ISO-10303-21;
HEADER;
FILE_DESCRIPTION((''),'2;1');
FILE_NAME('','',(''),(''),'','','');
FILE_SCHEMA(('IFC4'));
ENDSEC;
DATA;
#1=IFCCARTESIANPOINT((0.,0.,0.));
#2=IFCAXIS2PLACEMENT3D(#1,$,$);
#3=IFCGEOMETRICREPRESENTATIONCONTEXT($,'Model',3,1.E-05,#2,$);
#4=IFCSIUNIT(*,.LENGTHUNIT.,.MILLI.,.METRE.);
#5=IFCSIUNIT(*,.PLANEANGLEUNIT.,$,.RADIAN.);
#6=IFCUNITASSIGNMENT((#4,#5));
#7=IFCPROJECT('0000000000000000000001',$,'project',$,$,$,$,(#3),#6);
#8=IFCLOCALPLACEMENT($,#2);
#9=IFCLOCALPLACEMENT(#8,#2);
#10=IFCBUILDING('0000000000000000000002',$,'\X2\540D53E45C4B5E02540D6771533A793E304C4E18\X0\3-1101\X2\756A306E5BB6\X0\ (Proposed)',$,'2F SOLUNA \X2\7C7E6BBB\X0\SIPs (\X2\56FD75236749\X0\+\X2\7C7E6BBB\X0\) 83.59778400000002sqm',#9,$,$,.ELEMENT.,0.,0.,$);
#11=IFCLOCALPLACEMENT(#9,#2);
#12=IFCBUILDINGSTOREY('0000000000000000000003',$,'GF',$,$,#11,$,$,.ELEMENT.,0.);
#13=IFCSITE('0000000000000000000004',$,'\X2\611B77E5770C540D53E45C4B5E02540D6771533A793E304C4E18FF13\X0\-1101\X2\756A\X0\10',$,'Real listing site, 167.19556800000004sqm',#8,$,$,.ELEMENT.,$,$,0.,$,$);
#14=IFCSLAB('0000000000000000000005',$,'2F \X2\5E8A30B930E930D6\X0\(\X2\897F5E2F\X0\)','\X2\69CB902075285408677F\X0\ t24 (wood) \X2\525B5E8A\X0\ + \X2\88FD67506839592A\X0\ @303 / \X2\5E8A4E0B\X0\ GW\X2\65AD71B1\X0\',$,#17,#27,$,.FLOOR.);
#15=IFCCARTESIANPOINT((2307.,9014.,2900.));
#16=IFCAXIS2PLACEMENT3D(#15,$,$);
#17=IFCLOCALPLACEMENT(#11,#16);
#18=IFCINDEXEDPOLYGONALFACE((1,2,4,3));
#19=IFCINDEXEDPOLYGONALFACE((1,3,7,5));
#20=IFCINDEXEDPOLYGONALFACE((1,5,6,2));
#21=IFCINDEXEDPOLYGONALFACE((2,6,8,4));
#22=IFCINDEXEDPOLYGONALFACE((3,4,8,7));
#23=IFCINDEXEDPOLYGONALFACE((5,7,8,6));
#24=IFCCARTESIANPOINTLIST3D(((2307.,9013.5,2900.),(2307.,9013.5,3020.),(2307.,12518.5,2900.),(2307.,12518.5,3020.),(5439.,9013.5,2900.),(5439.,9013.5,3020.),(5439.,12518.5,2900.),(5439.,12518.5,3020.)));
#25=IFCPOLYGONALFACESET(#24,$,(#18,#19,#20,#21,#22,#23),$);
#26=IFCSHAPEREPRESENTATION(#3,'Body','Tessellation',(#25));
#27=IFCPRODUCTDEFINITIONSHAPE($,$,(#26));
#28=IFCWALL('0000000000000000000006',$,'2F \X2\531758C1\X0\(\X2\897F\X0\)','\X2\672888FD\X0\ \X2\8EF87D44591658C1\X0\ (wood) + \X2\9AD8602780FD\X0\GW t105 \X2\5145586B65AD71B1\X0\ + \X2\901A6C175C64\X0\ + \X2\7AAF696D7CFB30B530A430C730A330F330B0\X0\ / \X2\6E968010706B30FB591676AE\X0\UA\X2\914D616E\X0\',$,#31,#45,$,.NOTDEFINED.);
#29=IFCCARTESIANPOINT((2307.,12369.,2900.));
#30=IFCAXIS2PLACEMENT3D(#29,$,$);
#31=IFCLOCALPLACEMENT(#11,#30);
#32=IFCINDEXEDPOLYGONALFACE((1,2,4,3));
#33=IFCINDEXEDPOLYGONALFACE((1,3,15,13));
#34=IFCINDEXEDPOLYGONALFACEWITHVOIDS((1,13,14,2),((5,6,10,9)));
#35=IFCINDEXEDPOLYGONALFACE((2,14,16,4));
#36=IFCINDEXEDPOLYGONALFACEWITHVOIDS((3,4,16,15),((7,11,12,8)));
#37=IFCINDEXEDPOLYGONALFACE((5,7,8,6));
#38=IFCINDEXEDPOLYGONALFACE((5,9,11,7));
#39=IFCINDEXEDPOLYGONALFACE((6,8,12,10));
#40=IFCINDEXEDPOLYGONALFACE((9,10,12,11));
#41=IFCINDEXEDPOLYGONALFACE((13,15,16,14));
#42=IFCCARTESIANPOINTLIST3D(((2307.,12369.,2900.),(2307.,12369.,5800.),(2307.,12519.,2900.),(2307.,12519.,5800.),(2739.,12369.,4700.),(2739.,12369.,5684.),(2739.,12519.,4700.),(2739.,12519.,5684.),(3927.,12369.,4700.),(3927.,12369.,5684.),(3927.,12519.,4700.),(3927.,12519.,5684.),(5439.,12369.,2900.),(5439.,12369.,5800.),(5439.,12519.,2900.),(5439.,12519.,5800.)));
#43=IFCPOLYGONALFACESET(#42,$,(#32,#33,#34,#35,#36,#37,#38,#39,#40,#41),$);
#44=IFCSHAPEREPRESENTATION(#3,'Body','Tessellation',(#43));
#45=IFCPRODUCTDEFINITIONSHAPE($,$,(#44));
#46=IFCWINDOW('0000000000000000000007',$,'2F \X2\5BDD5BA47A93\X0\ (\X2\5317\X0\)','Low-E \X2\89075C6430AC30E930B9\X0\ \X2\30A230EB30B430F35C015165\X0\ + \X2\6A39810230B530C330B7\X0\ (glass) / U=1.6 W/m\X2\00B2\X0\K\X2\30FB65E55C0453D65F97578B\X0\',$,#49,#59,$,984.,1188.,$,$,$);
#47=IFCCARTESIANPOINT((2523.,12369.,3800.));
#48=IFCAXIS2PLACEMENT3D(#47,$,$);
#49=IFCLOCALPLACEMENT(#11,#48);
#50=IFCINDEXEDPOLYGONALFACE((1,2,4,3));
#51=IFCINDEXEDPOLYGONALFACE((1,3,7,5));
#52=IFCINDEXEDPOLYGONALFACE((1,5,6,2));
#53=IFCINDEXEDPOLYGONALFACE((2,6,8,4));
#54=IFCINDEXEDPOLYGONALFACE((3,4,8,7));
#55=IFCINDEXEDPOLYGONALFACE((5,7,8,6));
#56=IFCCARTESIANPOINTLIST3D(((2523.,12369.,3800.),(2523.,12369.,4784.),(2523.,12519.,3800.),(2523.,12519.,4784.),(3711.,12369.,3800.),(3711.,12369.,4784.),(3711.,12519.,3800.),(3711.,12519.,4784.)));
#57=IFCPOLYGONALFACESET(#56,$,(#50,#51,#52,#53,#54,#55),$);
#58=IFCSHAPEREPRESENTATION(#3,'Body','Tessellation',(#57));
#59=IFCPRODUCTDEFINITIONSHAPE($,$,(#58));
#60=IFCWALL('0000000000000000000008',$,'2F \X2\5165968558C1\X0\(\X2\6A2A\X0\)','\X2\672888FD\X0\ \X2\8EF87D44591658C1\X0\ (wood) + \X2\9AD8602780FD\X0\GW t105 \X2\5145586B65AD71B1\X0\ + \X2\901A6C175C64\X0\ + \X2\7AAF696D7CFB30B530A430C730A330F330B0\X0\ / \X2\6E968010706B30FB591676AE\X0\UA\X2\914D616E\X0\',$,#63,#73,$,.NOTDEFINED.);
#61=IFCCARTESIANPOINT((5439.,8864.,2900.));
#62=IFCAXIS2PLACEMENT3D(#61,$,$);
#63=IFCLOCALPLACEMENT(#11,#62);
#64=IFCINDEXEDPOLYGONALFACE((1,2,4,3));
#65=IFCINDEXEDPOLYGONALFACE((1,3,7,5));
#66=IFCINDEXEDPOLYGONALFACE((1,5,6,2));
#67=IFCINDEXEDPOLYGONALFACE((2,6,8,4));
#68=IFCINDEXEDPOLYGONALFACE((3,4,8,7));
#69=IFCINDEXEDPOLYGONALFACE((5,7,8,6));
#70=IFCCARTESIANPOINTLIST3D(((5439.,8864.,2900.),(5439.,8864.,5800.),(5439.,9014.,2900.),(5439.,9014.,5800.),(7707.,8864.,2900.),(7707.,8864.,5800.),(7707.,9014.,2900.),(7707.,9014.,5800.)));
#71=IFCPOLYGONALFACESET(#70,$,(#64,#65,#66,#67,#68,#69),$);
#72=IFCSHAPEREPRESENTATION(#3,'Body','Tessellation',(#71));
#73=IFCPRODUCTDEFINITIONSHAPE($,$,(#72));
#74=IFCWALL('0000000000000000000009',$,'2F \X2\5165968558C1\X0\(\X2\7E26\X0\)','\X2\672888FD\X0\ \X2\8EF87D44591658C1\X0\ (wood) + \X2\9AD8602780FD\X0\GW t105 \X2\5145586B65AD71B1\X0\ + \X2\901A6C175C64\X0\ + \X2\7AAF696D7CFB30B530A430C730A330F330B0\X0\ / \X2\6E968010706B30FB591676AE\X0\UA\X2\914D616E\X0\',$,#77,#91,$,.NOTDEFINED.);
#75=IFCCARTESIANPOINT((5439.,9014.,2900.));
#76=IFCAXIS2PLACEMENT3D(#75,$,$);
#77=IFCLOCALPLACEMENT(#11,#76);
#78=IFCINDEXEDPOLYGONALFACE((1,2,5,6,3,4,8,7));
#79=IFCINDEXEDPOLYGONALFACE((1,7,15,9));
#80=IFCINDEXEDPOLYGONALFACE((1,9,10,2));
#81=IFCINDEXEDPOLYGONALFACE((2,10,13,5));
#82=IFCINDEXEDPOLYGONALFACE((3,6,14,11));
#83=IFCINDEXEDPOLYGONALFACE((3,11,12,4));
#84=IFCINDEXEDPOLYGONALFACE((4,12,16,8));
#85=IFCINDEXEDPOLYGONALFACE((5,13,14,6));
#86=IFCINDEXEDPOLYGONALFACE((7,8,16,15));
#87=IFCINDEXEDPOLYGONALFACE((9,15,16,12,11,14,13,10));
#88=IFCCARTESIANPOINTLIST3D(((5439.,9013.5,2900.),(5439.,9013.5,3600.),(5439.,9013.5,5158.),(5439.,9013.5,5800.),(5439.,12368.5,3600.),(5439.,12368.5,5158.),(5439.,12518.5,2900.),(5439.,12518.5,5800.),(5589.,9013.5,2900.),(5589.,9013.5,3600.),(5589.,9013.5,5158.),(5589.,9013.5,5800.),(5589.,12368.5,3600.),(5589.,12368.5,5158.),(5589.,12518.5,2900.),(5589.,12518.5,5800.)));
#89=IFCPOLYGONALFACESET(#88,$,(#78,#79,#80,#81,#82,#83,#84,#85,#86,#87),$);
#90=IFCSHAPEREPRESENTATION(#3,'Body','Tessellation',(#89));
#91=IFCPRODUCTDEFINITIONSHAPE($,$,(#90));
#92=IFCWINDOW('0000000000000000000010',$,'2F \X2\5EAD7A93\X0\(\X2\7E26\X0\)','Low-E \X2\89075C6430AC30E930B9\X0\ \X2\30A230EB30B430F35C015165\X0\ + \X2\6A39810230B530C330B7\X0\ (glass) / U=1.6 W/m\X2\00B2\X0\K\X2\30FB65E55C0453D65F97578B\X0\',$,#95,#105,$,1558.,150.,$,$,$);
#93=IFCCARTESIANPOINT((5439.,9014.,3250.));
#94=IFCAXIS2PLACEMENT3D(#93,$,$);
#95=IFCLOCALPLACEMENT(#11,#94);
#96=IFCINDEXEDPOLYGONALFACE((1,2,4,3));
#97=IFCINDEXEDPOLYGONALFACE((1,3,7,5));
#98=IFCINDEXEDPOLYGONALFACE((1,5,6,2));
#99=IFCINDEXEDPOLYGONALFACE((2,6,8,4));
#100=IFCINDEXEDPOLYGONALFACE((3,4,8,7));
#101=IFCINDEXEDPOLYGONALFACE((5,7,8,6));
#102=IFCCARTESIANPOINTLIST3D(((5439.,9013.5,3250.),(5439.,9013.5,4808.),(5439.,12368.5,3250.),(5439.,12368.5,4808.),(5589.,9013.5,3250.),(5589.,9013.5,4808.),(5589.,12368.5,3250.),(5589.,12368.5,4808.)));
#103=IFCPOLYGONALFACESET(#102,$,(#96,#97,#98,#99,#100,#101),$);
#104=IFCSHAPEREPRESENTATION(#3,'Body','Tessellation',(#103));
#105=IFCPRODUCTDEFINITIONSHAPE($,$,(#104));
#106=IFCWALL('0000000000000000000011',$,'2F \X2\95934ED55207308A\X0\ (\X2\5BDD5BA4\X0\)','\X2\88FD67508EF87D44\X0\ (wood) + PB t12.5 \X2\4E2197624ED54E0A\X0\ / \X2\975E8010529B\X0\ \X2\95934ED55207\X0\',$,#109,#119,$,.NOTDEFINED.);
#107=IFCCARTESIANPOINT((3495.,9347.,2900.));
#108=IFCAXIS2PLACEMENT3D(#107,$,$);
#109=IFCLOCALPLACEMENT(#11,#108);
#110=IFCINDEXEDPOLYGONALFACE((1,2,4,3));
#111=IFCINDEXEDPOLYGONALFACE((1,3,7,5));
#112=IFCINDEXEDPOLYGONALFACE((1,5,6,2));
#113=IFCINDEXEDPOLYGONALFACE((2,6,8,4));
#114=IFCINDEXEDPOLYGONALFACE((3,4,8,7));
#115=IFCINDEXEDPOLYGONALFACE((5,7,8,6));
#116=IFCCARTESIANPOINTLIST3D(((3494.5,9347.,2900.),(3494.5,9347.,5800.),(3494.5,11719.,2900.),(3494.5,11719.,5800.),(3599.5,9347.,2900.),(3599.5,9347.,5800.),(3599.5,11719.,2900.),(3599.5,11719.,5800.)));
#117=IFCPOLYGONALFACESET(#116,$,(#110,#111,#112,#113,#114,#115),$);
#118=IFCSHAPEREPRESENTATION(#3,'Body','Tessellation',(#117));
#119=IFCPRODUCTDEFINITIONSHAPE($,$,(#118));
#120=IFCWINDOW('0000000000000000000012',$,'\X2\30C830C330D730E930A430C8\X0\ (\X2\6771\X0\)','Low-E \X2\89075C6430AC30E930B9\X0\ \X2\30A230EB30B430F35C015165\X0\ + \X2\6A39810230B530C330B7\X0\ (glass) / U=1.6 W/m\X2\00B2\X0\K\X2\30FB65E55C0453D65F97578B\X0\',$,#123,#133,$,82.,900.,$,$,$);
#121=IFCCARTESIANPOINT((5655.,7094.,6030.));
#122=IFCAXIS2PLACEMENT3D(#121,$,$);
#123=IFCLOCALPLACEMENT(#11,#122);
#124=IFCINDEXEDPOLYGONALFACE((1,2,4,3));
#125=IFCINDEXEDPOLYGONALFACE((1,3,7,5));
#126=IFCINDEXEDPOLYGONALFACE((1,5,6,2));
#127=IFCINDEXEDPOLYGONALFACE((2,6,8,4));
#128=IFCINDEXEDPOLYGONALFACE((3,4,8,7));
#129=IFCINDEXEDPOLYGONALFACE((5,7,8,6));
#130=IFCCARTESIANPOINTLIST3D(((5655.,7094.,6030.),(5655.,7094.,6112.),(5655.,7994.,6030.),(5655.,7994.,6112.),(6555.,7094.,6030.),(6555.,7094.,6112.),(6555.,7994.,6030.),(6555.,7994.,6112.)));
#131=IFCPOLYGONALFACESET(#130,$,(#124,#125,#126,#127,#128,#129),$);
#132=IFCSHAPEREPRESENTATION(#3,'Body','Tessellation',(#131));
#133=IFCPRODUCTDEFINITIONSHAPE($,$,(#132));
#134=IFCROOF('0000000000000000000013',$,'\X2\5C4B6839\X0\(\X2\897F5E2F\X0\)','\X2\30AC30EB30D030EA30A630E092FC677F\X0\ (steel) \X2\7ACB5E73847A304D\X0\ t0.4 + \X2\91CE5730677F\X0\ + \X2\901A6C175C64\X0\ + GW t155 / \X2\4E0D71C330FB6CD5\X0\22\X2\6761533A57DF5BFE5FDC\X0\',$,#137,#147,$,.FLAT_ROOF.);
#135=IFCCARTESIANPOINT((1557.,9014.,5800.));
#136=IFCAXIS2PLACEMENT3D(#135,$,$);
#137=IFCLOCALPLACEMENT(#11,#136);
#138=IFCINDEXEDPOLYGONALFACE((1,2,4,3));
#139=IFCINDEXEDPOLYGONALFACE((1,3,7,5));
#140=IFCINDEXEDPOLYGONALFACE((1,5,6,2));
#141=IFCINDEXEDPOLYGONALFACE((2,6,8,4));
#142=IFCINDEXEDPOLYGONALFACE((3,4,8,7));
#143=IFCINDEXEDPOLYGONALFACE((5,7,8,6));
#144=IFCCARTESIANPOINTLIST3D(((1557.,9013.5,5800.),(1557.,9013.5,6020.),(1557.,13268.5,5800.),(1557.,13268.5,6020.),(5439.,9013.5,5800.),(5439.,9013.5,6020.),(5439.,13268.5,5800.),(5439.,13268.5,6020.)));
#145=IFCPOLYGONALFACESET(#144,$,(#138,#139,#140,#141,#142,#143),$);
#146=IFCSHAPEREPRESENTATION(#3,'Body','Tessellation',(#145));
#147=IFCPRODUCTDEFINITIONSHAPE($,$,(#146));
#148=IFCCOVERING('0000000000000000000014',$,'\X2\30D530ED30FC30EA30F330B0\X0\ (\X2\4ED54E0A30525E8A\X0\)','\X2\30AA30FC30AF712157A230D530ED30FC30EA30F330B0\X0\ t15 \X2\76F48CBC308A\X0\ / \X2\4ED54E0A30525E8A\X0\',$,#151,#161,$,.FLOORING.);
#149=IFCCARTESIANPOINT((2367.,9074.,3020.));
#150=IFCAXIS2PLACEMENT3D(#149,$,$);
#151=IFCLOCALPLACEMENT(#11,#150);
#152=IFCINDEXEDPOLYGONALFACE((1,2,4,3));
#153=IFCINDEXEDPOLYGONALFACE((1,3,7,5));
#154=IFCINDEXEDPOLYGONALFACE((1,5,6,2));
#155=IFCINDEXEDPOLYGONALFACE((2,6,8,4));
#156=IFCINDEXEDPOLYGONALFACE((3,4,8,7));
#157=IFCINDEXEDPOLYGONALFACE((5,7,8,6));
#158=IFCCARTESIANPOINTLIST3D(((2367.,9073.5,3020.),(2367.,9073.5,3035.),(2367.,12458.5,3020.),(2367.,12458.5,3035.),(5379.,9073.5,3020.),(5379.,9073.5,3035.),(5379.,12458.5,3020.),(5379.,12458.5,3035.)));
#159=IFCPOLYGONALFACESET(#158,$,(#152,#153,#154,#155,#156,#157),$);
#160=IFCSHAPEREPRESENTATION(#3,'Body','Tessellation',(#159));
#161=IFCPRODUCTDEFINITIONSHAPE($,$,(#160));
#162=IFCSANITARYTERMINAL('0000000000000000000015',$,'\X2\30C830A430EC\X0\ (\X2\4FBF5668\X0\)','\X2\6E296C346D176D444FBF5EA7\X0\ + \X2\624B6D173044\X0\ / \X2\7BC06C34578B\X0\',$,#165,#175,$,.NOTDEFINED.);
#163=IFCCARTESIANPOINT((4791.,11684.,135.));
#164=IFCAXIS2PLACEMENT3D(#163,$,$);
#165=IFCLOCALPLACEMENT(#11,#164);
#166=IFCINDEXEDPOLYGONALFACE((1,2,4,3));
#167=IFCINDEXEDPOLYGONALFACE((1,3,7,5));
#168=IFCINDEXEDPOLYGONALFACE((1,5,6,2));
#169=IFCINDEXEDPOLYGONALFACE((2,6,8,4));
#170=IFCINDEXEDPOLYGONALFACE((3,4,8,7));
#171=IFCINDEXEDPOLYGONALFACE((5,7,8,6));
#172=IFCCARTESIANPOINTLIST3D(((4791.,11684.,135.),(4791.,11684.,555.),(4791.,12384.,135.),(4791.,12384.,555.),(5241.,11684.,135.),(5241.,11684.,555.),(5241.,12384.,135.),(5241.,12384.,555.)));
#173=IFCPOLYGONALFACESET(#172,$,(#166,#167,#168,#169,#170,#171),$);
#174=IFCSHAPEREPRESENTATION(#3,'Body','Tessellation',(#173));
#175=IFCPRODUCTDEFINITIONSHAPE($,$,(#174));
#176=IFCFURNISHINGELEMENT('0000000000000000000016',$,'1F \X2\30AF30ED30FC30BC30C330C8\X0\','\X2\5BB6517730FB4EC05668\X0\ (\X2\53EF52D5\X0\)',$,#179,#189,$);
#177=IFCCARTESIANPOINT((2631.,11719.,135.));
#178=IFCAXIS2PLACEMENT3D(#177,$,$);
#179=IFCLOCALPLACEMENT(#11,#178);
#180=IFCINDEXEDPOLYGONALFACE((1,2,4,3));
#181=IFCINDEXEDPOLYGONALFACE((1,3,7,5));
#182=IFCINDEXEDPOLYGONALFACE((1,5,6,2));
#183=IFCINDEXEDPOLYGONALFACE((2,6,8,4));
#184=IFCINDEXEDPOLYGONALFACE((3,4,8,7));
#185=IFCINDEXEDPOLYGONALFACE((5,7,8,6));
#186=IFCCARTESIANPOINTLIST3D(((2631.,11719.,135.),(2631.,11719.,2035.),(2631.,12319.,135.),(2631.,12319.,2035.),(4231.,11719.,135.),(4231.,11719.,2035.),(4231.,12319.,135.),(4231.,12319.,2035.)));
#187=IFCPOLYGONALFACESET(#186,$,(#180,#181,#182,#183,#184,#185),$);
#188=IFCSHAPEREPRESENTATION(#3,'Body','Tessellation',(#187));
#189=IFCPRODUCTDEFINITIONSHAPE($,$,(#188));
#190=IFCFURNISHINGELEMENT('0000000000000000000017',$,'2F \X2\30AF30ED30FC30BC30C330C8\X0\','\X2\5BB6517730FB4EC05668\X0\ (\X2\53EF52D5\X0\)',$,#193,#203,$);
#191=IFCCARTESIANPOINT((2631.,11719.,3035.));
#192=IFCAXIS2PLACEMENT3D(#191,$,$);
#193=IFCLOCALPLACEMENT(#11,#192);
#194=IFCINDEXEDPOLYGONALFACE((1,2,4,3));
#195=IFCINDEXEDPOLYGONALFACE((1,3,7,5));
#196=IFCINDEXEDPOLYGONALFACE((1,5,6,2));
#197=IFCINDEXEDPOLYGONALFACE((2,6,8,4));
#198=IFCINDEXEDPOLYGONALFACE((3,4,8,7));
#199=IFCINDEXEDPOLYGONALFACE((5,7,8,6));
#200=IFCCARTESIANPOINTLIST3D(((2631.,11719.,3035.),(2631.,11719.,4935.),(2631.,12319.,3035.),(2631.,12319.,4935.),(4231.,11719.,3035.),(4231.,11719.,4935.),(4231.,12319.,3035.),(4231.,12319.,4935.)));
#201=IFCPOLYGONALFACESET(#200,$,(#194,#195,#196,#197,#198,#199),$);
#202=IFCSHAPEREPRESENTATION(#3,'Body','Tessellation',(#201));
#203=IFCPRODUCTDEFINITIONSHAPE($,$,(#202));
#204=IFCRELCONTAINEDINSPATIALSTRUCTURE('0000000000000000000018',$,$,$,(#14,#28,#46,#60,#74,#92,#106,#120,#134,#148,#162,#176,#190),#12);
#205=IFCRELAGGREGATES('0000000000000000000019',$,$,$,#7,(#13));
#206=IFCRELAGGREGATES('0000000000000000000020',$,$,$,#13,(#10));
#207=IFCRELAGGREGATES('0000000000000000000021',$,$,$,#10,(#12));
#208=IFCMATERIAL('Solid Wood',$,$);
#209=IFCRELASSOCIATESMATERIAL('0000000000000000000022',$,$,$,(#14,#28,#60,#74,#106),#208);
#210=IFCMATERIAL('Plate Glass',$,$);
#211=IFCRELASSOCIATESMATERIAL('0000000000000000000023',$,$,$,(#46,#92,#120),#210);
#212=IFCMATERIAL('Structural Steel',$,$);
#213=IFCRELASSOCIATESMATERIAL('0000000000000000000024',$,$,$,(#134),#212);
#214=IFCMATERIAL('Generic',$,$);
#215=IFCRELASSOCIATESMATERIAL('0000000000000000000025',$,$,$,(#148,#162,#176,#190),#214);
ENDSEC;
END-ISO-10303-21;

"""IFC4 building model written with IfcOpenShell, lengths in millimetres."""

from ifc_helpers import new_model, si_unit, frame, frame_2d, origin, place, context, project, spatial, rectangle, extrude, material, element, fill, save


model = new_model("IFC4")

# Units and contexts
model_context = context("Model", 3, precision=1e-05, world=origin())
ifc_project = project(units=[si_unit("LENGTHUNIT", "METRE", prefix="MILLI"), si_unit("PLANEANGLEUNIT", "RADIAN")], contexts=[model_context])

# Site, building, storey
site_placement = place(None, origin())
site = spatial("IfcSite", under=ifc_project, at=site_placement, Name="愛知県名古屋市名東区社が丘３-1101番10", ObjectType="Real listing site, 167.19556800000004sqm", CompositionType="ELEMENT", RefElevation=0.0)
building_placement = place(site_placement, origin())
building = spatial("IfcBuilding", under=site, at=building_placement, Name="名古屋市名東区社が丘3-1101番の家 (Proposed)", ObjectType="2F SOLUNA 籾殻SIPs (国産杉+籾殻) 83.59778400000002sqm", CompositionType="ELEMENT", ElevationOfRefHeight=0.0, ElevationOfTerrain=0.0)
storey_placement = place(building_placement, origin())
storey = spatial("IfcBuildingStorey", under=building, at=storey_placement, Name="GF", CompositionType="ELEMENT", Elevation=0.0)

# Slab
ifc_material_1 = material(Name="Solid Wood")
slab_placement = place(storey_placement, frame((2307.0, 9014.0, 2900.0)))
element("IfcSlab", 1, at=slab_placement, inside=storey, material=ifc_material_1, Name="2F 床スラブ(西帯)", Description="構造用合板 t24 (wood) 剛床 + 製材根太 @303 / 床下 GW断熱", PredefinedType="FLOOR", context=model_context, shape_type="SweptSolid", body=[
    extrude(rectangle(XDim=3132.0, YDim=3505.0, at=frame_2d((1566.0, 1752.0))), frame((2307.0, 9014.0, 2900.0)), (0.0, 0.0, 1.0), 120.0),
])

# Wall, opening, window
wall_1_placement = place(storey_placement, frame((2307.0, 12369.0, 2900.0)))
wall_1 = element("IfcWall", 2, at=wall_1_placement, inside=storey, material=ifc_material_1, Name="2F 北壁(西)", Description="木製 軸組外壁 (wood) + 高性能GW t105 充填断熱 + 通気層 + 窯業系サイディング / 準耐火・外皮UA配慮", PredefinedType="NOTDEFINED", context=model_context, shape_type="SweptSolid", body=[
    extrude(rectangle(XDim=3132.0, YDim=150.0, at=frame_2d((1566.0, 75.0))), frame((2307.0, 12369.0, 2900.0)), (0.0, 0.0, 1.0), 2900.0),
])
opening_1_placement = place(storey_placement, frame((2523.0, 12369.0, 3800.0)))
opening_1 = element("IfcOpeningElement", 3, at=opening_1_placement, cuts=wall_1, PredefinedType="NOTDEFINED", context=model_context, shape_type="SweptSolid", body=[
    extrude(rectangle(XDim=1188.0, YDim=150.0, at=frame_2d((594.0, 75.0))), frame((2523.0, 12369.0, 3800.0)), (0.0, 0.0, 1.0), 984.0),
])
ifc_material_2 = material(Name="Plate Glass")
window_1_placement = place(storey_placement, frame((2523.0, 12369.0, 3800.0)))
window_1 = element("IfcWindow", 4, at=window_1_placement, inside=storey, material=ifc_material_2, Name="2F 寝室窓 (北)", Description="Low-E 複層ガラス アルゴン封入 + 樹脂サッシ (glass) / U=1.6 W/m²K・日射取得型", OverallHeight=984.0, OverallWidth=1188.0, context=model_context, shape_type="SweptSolid", body=[
    extrude(rectangle(XDim=1188.0, YDim=150.0, at=frame_2d((594.0, 75.0))), frame((2523.0, 12369.0, 3800.0)), (0.0, 0.0, 1.0), 984.0),
])
fill(opening_1, window_1)

# Wall
wall_2_placement = place(storey_placement, frame((5439.0, 8864.0, 2900.0)))
element("IfcWall", 5, at=wall_2_placement, inside=storey, material=ifc_material_1, Name="2F 入隅壁(横)", Description="木製 軸組外壁 (wood) + 高性能GW t105 充填断熱 + 通気層 + 窯業系サイディング / 準耐火・外皮UA配慮", PredefinedType="NOTDEFINED", context=model_context, shape_type="SweptSolid", body=[
    extrude(rectangle(XDim=2268.0, YDim=150.0, at=frame_2d((1134.0, 75.0))), frame((5439.0, 8864.0, 2900.0)), (0.0, 0.0, 1.0), 2900.0),
])

# Wall, opening, window
wall_3_placement = place(storey_placement, frame((5439.0, 9014.0, 2900.0)))
wall_3 = element("IfcWall", 6, at=wall_3_placement, inside=storey, material=ifc_material_1, Name="2F 入隅壁(縦)", Description="木製 軸組外壁 (wood) + 高性能GW t105 充填断熱 + 通気層 + 窯業系サイディング / 準耐火・外皮UA配慮", PredefinedType="NOTDEFINED", context=model_context, shape_type="SweptSolid", body=[
    extrude(rectangle(XDim=150.0, YDim=3505.0, at=frame_2d((75.0, 1752.0))), frame((5439.0, 9014.0, 2900.0)), (0.0, 0.0, 1.0), 2900.0),
])
opening_2_placement = place(storey_placement, frame((5439.0, 9014.0, 3250.0)))
opening_2 = element("IfcOpeningElement", 7, at=opening_2_placement, cuts=wall_3, PredefinedType="NOTDEFINED", context=model_context, shape_type="SweptSolid", body=[
    extrude(rectangle(XDim=150.0, YDim=3355.0, at=frame_2d((75.0, 1677.0))), frame((5439.0, 9014.0, 3250.0)), (0.0, 0.0, 1.0), 1558.0),
])
window_2_placement = place(storey_placement, frame((5439.0, 9014.0, 3250.0)))
window_2 = element("IfcWindow", 8, at=window_2_placement, inside=storey, material=ifc_material_2, Name="2F 庭窓(縦)", Description="Low-E 複層ガラス アルゴン封入 + 樹脂サッシ (glass) / U=1.6 W/m²K・日射取得型", OverallHeight=1558.0, OverallWidth=150.0, context=model_context, shape_type="SweptSolid", body=[
    extrude(rectangle(XDim=150.0, YDim=3355.0, at=frame_2d((75.0, 1677.0))), frame((5439.0, 9014.0, 3250.0)), (0.0, 0.0, 1.0), 1558.0),
])
fill(opening_2, window_2)

# Wall
wall_4_placement = place(storey_placement, frame((3495.0, 9347.0, 2900.0)))
element("IfcWall", 9, at=wall_4_placement, inside=storey, material=ifc_material_1, Name="2F 間仕切り (寝室)", Description="製材軸組 (wood) + PB t12.5 両面仕上 / 非耐力 間仕切", PredefinedType="NOTDEFINED", context=model_context, shape_type="SweptSolid", body=[
    extrude(rectangle(XDim=105.0, YDim=2372.0, at=frame_2d((52.0, 1186.0))), frame((3495.0, 9347.0, 2900.0)), (0.0, 0.0, 1.0), 2900.0),
])

# Window
window_3_placement = place(storey_placement, frame((5655.0, 7094.0, 6030.0)))
element("IfcWindow", 10, at=window_3_placement, inside=storey, material=ifc_material_2, Name="トップライト (東)", Description="Low-E 複層ガラス アルゴン封入 + 樹脂サッシ (glass) / U=1.6 W/m²K・日射取得型", OverallHeight=82.0, OverallWidth=900.0, context=model_context, shape_type="SweptSolid", body=[
    extrude(rectangle(XDim=900.0, YDim=900.0, at=frame_2d((450.0, 450.0))), frame((5655.0, 7094.0, 6030.0)), (0.0, 0.0, 1.0), 82.0),
])

# Roof
ifc_material_3 = material(Name="Structural Steel")
for number, where, name in (
    (11, (1557.0, 9014.0, 5800.0), "屋根(西帯)"),
):
    element("IfcRoof", number, at=place(storey_placement, frame(where)), inside=storey, material=ifc_material_3, Name=name, Description="ガルバリウム鋼板 (steel) 立平葺き t0.4 + 野地板 + 通気層 + GW t155 / 不燃・法22条区域対応", PredefinedType="FLAT_ROOF", context=model_context, shape_type="SweptSolid", body=[
        extrude(rectangle(XDim=3882.0, YDim=4255.0, at=frame_2d((1941.0, 2127.0))), frame((1557.0, 9014.0, 5800.0)), (0.0, 0.0, 1.0), 220.0),
    ])

# Covering
ifc_material_4 = material(Name="Generic")
covering_placement = place(storey_placement, frame((2367.0, 9074.0, 3020.0)))
element("IfcCovering", 12, at=covering_placement, inside=storey, material=ifc_material_4, Name="フローリング (仕上げ床)", Description="オーク無垢フローリング t15 直貼り / 仕上げ床", PredefinedType="FLOORING", context=model_context, shape_type="SweptSolid", body=[
    extrude(rectangle(XDim=3012.0, YDim=3385.0, at=frame_2d((1506.0, 1692.0))), frame((2367.0, 9074.0, 3020.0)), (0.0, 0.0, 1.0), 15.0),
])

# Sanitary terminal
sanitary_terminal_placement = place(storey_placement, frame((4791.0, 11684.0, 135.0)))
element("IfcSanitaryTerminal", 13, at=sanitary_terminal_placement, inside=storey, material=ifc_material_4, Name="トイレ (便器)", Description="温水洗浄便座 + 手洗い / 節水型", PredefinedType="NOTDEFINED", context=model_context, shape_type="SweptSolid", body=[
    extrude(rectangle(XDim=450.0, YDim=700.0, at=frame_2d((225.0, 350.0))), frame((4791.0, 11684.0, 135.0)), (0.0, 0.0, 1.0), 420.0),
])

# Furnishing elements
furnishing_1_placement = place(storey_placement, frame((2631.0, 11719.0, 135.0)))
element("IfcFurnishingElement", 14, at=furnishing_1_placement, inside=storey, material=ifc_material_4, Name="1F クローゼット", Description="家具・什器 (可動)", context=model_context, shape_type="SweptSolid", body=[
    extrude(rectangle(XDim=1600.0, YDim=600.0, at=frame_2d((800.0, 300.0))), frame((2631.0, 11719.0, 135.0)), (0.0, 0.0, 1.0), 1900.0),
])
furnishing_2_placement = place(storey_placement, frame((2631.0, 11719.0, 3035.0)))
element("IfcFurnishingElement", 15, at=furnishing_2_placement, inside=storey, material=ifc_material_4, Name="2F クローゼット", Description="家具・什器 (可動)", context=model_context, shape_type="SweptSolid", body=[
    extrude(rectangle(XDim=1600.0, YDim=600.0, at=frame_2d((800.0, 300.0))), frame((2631.0, 11719.0, 3035.0)), (0.0, 0.0, 1.0), 1900.0),
])

save(model, "model.ifc")
